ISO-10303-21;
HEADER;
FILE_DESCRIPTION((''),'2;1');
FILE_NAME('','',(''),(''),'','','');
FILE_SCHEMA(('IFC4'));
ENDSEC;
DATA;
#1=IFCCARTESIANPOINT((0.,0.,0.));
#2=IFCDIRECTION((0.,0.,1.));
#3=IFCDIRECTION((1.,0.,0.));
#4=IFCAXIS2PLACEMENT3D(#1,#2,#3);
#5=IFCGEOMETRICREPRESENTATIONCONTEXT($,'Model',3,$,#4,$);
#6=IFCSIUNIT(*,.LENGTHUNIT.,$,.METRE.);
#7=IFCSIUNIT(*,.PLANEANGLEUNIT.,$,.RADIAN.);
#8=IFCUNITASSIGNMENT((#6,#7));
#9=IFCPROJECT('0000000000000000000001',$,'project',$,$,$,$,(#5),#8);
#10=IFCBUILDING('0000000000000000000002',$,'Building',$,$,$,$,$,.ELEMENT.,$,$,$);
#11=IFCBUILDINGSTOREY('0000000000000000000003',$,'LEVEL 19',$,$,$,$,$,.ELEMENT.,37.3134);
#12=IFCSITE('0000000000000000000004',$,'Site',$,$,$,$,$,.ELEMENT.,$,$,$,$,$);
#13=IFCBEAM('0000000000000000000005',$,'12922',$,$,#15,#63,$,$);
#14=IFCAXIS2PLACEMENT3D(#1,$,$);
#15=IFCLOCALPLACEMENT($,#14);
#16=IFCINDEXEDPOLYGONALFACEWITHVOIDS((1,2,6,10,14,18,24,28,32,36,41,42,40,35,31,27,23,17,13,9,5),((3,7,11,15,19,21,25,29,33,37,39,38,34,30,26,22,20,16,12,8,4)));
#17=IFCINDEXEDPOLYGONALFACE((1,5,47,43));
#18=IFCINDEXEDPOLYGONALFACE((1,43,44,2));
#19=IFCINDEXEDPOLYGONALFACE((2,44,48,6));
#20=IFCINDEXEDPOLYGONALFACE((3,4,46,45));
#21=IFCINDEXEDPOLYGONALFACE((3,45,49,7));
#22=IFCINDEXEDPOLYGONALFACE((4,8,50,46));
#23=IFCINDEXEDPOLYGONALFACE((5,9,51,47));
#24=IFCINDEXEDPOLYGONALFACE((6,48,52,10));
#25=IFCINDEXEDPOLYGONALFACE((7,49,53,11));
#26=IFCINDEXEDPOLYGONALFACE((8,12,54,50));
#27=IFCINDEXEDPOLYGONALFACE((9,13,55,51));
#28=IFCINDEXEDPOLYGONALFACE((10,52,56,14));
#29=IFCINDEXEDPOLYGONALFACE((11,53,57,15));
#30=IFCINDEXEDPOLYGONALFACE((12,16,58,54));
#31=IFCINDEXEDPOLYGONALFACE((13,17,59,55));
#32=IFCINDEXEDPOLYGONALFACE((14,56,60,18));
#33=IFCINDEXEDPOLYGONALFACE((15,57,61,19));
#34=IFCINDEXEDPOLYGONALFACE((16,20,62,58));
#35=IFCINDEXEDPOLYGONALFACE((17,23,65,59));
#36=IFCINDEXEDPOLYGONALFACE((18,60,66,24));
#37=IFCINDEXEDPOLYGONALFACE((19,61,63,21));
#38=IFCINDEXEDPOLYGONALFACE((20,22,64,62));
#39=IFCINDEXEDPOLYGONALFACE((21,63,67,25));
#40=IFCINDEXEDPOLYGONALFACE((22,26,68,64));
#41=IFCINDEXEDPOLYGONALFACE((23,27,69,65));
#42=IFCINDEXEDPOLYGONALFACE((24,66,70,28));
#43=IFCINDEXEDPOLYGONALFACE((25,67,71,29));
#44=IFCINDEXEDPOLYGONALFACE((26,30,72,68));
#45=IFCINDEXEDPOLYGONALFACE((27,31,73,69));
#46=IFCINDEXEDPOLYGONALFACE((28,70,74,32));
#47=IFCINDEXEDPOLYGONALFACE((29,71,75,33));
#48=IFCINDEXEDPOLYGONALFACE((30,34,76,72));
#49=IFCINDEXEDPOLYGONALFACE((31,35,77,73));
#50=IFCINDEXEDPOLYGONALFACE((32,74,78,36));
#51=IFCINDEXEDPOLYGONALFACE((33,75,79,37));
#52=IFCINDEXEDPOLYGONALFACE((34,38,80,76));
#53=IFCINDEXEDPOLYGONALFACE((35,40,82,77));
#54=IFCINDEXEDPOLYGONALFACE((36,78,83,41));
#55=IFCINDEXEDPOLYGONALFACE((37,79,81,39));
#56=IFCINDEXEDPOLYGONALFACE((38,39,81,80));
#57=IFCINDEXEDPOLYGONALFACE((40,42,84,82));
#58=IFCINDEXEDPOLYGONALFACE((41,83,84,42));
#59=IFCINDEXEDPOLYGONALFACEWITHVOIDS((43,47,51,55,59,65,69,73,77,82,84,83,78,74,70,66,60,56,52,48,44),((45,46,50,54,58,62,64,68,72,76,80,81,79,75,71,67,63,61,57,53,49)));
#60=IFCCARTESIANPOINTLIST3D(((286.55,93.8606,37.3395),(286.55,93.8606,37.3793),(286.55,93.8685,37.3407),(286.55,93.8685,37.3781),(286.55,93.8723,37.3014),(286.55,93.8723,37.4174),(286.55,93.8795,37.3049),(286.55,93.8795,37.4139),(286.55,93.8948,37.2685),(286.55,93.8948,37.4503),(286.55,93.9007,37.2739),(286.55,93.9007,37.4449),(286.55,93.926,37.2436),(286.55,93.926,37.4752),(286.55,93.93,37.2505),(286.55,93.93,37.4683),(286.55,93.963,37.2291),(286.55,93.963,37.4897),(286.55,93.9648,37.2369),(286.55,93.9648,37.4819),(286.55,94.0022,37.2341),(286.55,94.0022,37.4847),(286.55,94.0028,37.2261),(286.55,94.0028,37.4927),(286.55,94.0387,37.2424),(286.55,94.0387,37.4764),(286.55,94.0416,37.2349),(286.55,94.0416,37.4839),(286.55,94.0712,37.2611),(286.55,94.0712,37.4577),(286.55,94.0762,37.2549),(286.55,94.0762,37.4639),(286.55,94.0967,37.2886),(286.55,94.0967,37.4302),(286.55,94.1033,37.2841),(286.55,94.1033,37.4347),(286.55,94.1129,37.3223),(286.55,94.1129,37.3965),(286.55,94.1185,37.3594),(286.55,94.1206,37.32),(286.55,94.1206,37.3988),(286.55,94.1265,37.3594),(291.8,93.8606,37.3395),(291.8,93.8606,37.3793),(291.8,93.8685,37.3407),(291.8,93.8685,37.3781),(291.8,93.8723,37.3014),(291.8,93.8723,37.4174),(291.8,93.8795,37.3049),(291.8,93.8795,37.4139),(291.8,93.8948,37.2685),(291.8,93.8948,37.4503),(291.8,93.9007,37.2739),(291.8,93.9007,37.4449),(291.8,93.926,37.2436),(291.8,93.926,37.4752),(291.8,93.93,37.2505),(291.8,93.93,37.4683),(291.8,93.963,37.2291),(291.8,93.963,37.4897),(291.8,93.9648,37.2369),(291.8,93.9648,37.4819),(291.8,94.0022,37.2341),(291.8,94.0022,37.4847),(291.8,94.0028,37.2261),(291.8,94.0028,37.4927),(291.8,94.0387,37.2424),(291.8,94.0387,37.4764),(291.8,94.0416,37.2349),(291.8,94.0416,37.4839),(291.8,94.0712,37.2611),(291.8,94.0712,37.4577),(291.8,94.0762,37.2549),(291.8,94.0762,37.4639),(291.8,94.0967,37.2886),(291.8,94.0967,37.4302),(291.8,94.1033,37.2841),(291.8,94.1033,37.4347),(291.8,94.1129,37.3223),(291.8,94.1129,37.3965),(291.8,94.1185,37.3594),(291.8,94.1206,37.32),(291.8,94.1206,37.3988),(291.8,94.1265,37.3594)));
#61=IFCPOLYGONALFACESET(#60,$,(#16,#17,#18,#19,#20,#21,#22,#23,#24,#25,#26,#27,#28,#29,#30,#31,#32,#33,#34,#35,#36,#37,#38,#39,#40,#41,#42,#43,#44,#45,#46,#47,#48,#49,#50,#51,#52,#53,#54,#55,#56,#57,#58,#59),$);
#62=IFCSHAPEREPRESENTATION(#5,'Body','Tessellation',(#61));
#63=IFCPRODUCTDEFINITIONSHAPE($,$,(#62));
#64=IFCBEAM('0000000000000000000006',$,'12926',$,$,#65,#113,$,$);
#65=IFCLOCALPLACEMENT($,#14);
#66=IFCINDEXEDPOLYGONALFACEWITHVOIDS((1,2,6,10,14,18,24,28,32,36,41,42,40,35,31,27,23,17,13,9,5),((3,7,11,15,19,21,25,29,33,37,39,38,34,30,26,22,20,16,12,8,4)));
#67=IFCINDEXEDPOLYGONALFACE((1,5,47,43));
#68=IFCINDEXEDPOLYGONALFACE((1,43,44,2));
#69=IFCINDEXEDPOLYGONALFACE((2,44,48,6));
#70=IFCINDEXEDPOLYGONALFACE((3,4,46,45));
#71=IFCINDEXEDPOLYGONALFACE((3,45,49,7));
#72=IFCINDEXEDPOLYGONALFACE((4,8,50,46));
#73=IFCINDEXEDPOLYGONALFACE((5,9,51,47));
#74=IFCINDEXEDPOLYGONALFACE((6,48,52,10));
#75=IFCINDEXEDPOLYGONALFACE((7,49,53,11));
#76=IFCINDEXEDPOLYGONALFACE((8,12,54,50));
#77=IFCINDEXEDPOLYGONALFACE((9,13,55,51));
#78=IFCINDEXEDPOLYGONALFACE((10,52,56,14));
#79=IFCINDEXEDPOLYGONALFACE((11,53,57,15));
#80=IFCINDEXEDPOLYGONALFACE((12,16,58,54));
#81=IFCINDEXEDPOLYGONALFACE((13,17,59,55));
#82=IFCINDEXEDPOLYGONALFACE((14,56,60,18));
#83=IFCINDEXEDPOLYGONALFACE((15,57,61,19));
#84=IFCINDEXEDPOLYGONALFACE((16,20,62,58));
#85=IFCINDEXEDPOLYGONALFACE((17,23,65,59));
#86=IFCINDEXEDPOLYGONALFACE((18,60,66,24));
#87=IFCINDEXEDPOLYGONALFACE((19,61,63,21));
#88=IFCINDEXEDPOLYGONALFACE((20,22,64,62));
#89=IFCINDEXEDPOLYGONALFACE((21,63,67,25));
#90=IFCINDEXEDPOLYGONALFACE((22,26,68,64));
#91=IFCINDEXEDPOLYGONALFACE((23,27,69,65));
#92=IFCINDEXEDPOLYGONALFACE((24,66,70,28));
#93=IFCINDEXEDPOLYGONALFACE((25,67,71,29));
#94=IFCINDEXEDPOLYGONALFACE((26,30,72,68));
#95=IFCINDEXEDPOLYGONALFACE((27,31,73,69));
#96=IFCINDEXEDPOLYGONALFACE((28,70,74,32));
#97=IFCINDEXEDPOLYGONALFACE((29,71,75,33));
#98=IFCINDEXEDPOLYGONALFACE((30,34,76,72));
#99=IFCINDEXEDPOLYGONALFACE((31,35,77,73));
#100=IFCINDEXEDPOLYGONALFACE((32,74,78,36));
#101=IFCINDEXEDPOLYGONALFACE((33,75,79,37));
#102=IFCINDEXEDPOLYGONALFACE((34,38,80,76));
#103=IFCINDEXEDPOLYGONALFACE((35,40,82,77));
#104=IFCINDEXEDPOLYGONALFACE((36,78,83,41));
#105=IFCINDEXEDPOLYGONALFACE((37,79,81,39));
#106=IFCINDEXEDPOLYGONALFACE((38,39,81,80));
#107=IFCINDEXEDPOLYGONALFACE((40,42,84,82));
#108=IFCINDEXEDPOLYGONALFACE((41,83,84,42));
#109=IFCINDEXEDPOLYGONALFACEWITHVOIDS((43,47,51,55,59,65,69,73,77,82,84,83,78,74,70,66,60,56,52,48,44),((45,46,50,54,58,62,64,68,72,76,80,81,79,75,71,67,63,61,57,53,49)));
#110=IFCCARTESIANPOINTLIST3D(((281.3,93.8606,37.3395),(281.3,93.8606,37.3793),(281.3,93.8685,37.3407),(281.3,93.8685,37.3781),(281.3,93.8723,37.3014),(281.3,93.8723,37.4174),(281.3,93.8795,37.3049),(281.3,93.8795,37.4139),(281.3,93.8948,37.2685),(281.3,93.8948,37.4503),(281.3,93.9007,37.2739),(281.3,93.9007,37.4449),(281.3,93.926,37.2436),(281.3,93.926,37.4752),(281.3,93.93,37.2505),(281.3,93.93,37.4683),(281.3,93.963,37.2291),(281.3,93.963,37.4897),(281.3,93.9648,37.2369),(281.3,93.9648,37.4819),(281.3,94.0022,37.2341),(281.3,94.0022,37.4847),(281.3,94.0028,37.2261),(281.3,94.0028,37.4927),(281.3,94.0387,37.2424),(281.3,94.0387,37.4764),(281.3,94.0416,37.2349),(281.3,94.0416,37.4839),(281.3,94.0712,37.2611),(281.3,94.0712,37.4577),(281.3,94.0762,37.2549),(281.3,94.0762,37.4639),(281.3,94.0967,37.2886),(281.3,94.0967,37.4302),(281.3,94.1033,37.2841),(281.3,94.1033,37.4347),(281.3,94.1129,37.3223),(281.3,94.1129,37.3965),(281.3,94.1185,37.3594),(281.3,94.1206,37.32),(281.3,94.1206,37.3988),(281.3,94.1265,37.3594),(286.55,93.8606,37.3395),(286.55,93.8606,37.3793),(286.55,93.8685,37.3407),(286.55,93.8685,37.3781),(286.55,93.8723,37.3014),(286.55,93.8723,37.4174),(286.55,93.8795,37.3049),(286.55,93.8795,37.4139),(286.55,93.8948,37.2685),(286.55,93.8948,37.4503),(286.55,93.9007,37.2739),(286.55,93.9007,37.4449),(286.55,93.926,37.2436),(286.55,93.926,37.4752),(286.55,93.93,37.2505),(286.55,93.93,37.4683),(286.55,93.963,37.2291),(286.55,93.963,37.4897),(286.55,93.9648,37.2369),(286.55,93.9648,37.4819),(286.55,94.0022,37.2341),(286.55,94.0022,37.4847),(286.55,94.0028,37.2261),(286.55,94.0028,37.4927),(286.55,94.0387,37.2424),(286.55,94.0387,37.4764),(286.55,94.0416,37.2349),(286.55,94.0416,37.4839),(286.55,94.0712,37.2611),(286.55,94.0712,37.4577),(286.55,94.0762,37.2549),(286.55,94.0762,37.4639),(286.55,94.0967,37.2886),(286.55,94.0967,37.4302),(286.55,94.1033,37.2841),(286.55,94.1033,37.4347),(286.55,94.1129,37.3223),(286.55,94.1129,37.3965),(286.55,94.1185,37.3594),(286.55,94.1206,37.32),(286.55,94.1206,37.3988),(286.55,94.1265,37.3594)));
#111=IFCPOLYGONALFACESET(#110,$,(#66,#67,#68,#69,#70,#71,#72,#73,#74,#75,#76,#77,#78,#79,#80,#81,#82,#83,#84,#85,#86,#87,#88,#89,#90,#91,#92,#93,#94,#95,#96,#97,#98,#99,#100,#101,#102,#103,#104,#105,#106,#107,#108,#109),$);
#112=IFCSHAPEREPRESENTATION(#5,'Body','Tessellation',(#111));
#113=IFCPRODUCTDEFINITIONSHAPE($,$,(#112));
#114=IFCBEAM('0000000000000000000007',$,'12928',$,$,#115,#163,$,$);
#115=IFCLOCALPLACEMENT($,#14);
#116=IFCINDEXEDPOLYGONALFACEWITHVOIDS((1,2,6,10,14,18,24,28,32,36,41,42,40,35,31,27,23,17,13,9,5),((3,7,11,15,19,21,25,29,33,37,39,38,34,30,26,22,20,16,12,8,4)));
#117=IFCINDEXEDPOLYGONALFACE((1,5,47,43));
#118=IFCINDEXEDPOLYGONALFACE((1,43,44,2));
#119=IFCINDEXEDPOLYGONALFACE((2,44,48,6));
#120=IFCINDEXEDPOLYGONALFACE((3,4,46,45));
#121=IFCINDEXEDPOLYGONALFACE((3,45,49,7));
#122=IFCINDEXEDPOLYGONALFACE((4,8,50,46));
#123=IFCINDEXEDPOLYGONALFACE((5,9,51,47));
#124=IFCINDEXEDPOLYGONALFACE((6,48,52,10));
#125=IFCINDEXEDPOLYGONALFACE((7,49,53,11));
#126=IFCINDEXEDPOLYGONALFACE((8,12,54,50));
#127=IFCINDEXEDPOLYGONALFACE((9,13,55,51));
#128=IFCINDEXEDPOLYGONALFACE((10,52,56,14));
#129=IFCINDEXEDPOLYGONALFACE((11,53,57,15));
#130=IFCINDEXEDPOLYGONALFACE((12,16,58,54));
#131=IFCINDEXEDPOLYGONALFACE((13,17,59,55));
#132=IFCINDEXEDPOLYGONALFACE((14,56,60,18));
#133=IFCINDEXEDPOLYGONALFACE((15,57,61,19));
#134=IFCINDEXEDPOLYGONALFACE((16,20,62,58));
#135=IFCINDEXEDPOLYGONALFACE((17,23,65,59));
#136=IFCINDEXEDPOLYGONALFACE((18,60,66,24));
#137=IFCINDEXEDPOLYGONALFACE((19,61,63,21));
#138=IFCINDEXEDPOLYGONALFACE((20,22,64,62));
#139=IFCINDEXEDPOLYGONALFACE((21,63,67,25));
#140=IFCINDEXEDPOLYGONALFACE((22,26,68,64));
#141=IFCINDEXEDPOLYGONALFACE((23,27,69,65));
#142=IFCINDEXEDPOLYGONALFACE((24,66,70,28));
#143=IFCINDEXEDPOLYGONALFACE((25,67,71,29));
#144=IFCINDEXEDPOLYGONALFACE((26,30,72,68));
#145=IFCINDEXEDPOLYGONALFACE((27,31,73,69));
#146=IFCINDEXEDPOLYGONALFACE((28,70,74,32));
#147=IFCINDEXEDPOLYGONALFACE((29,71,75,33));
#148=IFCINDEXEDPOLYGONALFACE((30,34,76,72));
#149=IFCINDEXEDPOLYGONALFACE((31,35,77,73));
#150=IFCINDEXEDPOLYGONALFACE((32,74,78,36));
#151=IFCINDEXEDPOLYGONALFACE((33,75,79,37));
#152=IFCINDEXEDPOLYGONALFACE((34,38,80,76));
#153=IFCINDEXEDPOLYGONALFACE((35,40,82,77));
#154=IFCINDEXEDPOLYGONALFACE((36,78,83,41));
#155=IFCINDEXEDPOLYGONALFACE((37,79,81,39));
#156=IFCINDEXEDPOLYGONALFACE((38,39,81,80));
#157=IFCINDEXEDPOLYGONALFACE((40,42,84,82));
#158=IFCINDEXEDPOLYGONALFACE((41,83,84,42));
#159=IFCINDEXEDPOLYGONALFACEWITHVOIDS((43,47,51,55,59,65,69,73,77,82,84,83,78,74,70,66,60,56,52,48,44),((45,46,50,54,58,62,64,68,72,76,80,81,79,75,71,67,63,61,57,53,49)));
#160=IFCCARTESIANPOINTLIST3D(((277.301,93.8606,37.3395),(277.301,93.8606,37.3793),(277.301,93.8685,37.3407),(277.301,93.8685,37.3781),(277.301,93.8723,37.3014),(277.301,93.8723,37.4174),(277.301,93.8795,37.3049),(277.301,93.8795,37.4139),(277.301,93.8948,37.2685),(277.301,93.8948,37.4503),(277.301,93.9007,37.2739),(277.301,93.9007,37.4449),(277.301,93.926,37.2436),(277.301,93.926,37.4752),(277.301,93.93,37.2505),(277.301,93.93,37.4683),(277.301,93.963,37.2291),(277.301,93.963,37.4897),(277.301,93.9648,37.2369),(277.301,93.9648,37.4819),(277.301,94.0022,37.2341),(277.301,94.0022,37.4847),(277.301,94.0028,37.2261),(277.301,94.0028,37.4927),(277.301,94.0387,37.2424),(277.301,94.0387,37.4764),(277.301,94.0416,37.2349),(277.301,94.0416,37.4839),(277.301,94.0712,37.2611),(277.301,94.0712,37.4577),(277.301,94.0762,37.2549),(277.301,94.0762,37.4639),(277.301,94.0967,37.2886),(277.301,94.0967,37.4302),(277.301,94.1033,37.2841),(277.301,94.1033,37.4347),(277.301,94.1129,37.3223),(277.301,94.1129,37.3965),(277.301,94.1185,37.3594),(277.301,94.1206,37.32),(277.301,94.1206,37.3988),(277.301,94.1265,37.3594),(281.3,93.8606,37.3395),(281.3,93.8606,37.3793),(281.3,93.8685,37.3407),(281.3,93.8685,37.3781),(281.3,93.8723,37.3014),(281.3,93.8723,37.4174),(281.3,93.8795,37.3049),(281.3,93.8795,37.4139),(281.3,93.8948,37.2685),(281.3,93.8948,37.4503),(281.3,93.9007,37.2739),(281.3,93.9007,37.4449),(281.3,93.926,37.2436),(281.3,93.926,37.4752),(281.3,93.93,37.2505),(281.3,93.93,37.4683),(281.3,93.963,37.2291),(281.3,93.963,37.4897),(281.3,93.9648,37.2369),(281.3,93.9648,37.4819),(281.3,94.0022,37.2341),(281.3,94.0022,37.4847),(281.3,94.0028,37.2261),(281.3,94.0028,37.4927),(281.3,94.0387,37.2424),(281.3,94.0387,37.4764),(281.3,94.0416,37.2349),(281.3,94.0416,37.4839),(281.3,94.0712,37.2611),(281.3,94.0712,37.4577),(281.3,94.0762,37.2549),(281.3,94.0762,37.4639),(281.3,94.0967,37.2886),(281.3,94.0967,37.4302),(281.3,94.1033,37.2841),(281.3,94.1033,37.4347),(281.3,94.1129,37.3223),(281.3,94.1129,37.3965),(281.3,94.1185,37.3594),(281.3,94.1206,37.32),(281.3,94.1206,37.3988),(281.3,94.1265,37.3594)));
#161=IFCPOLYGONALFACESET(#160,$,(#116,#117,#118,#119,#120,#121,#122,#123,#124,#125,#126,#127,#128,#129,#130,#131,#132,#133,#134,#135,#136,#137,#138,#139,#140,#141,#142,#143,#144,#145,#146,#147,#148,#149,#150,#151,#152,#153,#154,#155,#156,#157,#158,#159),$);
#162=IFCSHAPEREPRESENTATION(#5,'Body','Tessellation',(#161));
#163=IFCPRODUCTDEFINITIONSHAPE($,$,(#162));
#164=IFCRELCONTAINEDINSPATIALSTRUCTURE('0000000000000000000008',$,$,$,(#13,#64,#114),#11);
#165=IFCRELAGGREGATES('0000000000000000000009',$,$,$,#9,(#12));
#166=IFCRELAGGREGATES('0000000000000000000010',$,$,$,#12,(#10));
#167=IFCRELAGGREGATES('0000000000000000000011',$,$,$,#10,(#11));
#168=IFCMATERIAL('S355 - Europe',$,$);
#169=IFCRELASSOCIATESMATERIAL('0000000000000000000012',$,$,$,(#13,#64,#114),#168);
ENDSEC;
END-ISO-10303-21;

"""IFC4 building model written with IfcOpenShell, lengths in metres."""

from ifc_helpers import new_model, si_unit, frame, origin_with_axes, origin_2d_with_axis, place, context, project, spatial, hollow_circle, extrude, material, material_profile, profile_set, profile_usage, element, save


model = new_model("IFC4")

# Units and contexts
model_context = context("Model", 3, world=origin_with_axes())
ifc_project = project(units=[si_unit("LENGTHUNIT", "METRE"), si_unit("PLANEANGLEUNIT", "RADIAN")], contexts=[model_context])

# Site, building, storey
site = spatial("IfcSite", under=ifc_project, Name="Site", CompositionType="ELEMENT")
building = spatial("IfcBuilding", under=site, Name="Building", CompositionType="ELEMENT")
storey = spatial("IfcBuildingStorey", under=building, Name="LEVEL 19", CompositionType="ELEMENT", Elevation=37.3134)

# Beams
ifc_material = material(Name="S355 - Europe")
ifc_material_profile_1 = material_profile(ifc_material, hollow_circle(Radius=0.1337, WallThickness=0.008, at=origin_2d_with_axis()))
ifc_profile_set_1 = profile_set([ifc_material_profile_1])
ifc_profile_usage_1 = profile_usage(ifc_profile_set_1, cardinal=10)
beam_1_placement = place(None, frame((286.55, 93.9928, 37.3594), z_axis=(1.0, 0.0, 0.0), x_axis=(0.0, 1.0, 0.0)))
element("IfcBeam", 1, at=beam_1_placement, inside=storey, material=ifc_profile_usage_1, Name="12922", context=model_context, shape_type="SweptSolid", body=[
    extrude(hollow_circle(Radius=0.1337, WallThickness=0.008, at=origin_2d_with_axis()), origin_with_axes(), (0.0, 0.0, 1.0), 5.25),
])
ifc_material_profile_2 = material_profile(ifc_material, hollow_circle(Radius=0.1337, WallThickness=0.008, at=origin_2d_with_axis()))
ifc_profile_set_2 = profile_set([ifc_material_profile_2])
ifc_profile_usage_2 = profile_usage(ifc_profile_set_2, cardinal=10)
beam_2_placement = place(None, frame((281.3, 93.9928, 37.3594), z_axis=(1.0, 0.0, 0.0), x_axis=(0.0, 1.0, 0.0)))
element("IfcBeam", 2, at=beam_2_placement, inside=storey, material=ifc_profile_usage_2, Name="12926", context=model_context, shape_type="SweptSolid", body=[
    extrude(hollow_circle(Radius=0.1337, WallThickness=0.008, at=origin_2d_with_axis()), origin_with_axes(), (0.0, 0.0, 1.0), 5.25),
])
ifc_material_profile_3 = material_profile(ifc_material, hollow_circle(Radius=0.1337, WallThickness=0.008, at=origin_2d_with_axis()))
ifc_profile_set_3 = profile_set([ifc_material_profile_3])
ifc_profile_usage_3 = profile_usage(ifc_profile_set_3, cardinal=10)
beam_3_placement = place(None, frame((277.301, 93.9928, 37.3594), z_axis=(1.0, 0.0, 0.0), x_axis=(0.0, 1.0, 0.0)))
element("IfcBeam", 3, at=beam_3_placement, inside=storey, material=ifc_profile_usage_3, Name="12928", context=model_context, shape_type="SweptSolid", body=[
    extrude(hollow_circle(Radius=0.1337, WallThickness=0.008, at=origin_2d_with_axis()), origin_with_axes(), (0.0, 0.0, 1.0), 3.999),
])

save(model, "model.ifc")
